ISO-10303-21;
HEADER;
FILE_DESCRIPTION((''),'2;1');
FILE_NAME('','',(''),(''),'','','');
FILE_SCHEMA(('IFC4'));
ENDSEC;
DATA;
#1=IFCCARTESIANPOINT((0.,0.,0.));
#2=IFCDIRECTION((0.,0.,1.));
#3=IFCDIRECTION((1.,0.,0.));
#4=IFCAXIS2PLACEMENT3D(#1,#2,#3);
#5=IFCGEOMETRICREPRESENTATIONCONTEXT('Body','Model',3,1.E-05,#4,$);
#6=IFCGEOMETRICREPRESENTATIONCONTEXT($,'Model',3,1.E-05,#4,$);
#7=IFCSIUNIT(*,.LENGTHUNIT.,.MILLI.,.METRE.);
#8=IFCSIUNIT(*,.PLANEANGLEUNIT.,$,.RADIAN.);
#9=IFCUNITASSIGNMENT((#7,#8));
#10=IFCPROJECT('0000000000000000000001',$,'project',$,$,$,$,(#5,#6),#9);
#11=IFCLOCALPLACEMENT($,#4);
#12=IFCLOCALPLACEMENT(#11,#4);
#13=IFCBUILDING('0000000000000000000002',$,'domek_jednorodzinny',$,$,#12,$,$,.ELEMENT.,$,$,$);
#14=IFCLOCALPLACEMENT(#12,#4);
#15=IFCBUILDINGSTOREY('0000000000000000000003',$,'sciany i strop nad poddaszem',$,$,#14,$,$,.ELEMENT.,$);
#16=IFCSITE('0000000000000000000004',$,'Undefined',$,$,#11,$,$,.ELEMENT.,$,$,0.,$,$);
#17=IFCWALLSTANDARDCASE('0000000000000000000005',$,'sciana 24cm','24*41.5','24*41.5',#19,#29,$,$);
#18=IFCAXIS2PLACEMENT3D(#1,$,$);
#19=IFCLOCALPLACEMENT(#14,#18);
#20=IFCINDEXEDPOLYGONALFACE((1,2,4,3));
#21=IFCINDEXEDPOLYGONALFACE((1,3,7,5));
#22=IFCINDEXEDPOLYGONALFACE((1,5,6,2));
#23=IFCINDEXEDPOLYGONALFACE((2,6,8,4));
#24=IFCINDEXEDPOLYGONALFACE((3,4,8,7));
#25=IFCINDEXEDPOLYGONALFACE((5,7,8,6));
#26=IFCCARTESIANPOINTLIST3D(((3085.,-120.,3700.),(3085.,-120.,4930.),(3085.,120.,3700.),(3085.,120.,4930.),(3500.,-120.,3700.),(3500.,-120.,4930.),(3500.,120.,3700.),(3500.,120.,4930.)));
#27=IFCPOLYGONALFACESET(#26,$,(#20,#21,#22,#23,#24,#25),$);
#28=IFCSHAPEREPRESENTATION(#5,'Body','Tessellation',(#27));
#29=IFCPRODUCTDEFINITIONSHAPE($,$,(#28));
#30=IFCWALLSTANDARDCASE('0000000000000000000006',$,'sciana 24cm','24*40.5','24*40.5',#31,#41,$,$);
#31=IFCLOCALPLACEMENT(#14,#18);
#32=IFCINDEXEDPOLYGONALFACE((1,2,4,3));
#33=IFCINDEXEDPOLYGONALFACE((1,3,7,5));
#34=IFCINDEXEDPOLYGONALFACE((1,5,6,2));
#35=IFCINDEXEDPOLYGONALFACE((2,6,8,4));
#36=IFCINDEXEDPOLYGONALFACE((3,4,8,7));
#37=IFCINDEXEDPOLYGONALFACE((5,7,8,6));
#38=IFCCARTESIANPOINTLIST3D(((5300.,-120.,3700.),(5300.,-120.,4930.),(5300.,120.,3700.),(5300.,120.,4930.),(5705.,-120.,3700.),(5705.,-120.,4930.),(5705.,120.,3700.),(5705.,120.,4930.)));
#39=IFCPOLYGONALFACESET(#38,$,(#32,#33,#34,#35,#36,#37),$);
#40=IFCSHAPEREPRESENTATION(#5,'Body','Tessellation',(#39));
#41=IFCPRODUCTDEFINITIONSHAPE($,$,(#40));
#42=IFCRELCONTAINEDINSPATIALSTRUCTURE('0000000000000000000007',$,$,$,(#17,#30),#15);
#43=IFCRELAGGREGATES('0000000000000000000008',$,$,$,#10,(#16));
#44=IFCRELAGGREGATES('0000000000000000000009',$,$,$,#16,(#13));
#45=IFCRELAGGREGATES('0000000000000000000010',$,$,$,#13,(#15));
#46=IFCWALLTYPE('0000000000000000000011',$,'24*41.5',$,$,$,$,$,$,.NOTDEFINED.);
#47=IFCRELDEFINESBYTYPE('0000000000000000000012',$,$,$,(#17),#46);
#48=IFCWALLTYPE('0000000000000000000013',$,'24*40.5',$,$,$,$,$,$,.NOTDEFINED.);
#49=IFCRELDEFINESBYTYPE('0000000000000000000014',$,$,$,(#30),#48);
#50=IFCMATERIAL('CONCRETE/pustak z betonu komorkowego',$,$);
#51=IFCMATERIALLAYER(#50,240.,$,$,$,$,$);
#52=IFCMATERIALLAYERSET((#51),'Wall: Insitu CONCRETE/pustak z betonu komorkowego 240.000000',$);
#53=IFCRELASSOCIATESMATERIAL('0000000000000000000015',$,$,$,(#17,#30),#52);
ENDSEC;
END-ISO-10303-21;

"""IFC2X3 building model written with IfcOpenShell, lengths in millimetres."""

from ifc_helpers import new_model, si_unit, frame, frame_2d, origin_with_axes, place, context, project, spatial, rectangle, extrude, material, layer, layer_set, layer_usage, type_object, element, save


model = new_model("IFC2X3")

# Units and contexts
model_context_1 = context("Model", 3, precision=1e-05, world=origin_with_axes(), identifier="Body")
model_context_2 = context("Model", 3, precision=1e-05, world=origin_with_axes())
ifc_project = project(units=[si_unit("LENGTHUNIT", "METRE", prefix="MILLI"), si_unit("PLANEANGLEUNIT", "RADIAN")], contexts=[model_context_1, model_context_2])

# Site, building, storey
site_placement = place(None, origin_with_axes())
site = spatial("IfcSite", under=ifc_project, at=site_placement, Name="Undefined", CompositionType="ELEMENT", RefElevation=0.0)
building_placement = place(site_placement, origin_with_axes())
building = spatial("IfcBuilding", under=site, at=building_placement, Name="domek_jednorodzinny", CompositionType="ELEMENT")
storey_placement = place(building_placement, origin_with_axes())
storey = spatial("IfcBuildingStorey", under=building, at=storey_placement, Name="sciany i strop nad poddaszem", CompositionType="ELEMENT")

# Shared definitions
ifc_material_1 = material(Name="CONCRETE/pustak z betonu komorkowego")

# Shared definitions
ifc_layer_1 = layer(ifc_material_1, 240.0)
ifc_layer_set_1 = layer_set([ifc_layer_1], Name="Wall: Insitu CONCRETE/pustak z betonu komorkowego 240.000000")

# Walls
ifc_layer_usage_1 = layer_usage(ifc_layer_set_1, "AXIS2", "POSITIVE", -120.0)
wall_type_1 = type_object("IfcWallType", Name="24*41.5", PredefinedType="NOTDEFINED")
wall_1_placement = place(storey_placement, frame((3085.0, 0.0, 3700.0), z_axis=(0.0, 0.0, 1.0), x_axis=(1.0, 0.0, 0.0)))
element("IfcWallStandardCase", 1, at=wall_1_placement, inside=storey, type_object=wall_type_1, material=ifc_layer_usage_1, Name="sciana 24cm", Description="24*41.5", ObjectType="24*41.5", context=model_context_1, shape_type="SweptSolid", body=[
    extrude(rectangle(XDim=415.0, YDim=240.0, at=frame_2d((0.0, 207.5), x_axis=(0.0, -1.0))), frame((0.0, 0.0, 0.0), z_axis=(0.0, 0.0, 1.0), x_axis=(0.0, -1.0, 0.0)), (0.0, 0.0, 1.0), 1230.0),
])
ifc_layer_usage_2 = layer_usage(ifc_layer_set_1, "AXIS2", "POSITIVE", -120.0)
wall_type_2 = type_object("IfcWallType", Name="24*40.5", PredefinedType="NOTDEFINED")
wall_2_placement = place(storey_placement, frame((5300.0, 0.0, 3700.0), z_axis=(0.0, 0.0, 1.0), x_axis=(1.0, 0.0, 0.0)))
element("IfcWallStandardCase", 2, at=wall_2_placement, inside=storey, type_object=wall_type_2, material=ifc_layer_usage_2, Name="sciana 24cm", Description="24*40.5", ObjectType="24*40.5", context=model_context_1, shape_type="SweptSolid", body=[
    extrude(rectangle(XDim=405.0, YDim=240.0, at=frame_2d((0.0, 202.5), x_axis=(0.0, -1.0))), frame((0.0, 0.0, 0.0), z_axis=(0.0, 0.0, 1.0), x_axis=(0.0, -1.0, 0.0)), (0.0, 0.0, 1.0), 1230.0),
])

save(model, "model.ifc")
